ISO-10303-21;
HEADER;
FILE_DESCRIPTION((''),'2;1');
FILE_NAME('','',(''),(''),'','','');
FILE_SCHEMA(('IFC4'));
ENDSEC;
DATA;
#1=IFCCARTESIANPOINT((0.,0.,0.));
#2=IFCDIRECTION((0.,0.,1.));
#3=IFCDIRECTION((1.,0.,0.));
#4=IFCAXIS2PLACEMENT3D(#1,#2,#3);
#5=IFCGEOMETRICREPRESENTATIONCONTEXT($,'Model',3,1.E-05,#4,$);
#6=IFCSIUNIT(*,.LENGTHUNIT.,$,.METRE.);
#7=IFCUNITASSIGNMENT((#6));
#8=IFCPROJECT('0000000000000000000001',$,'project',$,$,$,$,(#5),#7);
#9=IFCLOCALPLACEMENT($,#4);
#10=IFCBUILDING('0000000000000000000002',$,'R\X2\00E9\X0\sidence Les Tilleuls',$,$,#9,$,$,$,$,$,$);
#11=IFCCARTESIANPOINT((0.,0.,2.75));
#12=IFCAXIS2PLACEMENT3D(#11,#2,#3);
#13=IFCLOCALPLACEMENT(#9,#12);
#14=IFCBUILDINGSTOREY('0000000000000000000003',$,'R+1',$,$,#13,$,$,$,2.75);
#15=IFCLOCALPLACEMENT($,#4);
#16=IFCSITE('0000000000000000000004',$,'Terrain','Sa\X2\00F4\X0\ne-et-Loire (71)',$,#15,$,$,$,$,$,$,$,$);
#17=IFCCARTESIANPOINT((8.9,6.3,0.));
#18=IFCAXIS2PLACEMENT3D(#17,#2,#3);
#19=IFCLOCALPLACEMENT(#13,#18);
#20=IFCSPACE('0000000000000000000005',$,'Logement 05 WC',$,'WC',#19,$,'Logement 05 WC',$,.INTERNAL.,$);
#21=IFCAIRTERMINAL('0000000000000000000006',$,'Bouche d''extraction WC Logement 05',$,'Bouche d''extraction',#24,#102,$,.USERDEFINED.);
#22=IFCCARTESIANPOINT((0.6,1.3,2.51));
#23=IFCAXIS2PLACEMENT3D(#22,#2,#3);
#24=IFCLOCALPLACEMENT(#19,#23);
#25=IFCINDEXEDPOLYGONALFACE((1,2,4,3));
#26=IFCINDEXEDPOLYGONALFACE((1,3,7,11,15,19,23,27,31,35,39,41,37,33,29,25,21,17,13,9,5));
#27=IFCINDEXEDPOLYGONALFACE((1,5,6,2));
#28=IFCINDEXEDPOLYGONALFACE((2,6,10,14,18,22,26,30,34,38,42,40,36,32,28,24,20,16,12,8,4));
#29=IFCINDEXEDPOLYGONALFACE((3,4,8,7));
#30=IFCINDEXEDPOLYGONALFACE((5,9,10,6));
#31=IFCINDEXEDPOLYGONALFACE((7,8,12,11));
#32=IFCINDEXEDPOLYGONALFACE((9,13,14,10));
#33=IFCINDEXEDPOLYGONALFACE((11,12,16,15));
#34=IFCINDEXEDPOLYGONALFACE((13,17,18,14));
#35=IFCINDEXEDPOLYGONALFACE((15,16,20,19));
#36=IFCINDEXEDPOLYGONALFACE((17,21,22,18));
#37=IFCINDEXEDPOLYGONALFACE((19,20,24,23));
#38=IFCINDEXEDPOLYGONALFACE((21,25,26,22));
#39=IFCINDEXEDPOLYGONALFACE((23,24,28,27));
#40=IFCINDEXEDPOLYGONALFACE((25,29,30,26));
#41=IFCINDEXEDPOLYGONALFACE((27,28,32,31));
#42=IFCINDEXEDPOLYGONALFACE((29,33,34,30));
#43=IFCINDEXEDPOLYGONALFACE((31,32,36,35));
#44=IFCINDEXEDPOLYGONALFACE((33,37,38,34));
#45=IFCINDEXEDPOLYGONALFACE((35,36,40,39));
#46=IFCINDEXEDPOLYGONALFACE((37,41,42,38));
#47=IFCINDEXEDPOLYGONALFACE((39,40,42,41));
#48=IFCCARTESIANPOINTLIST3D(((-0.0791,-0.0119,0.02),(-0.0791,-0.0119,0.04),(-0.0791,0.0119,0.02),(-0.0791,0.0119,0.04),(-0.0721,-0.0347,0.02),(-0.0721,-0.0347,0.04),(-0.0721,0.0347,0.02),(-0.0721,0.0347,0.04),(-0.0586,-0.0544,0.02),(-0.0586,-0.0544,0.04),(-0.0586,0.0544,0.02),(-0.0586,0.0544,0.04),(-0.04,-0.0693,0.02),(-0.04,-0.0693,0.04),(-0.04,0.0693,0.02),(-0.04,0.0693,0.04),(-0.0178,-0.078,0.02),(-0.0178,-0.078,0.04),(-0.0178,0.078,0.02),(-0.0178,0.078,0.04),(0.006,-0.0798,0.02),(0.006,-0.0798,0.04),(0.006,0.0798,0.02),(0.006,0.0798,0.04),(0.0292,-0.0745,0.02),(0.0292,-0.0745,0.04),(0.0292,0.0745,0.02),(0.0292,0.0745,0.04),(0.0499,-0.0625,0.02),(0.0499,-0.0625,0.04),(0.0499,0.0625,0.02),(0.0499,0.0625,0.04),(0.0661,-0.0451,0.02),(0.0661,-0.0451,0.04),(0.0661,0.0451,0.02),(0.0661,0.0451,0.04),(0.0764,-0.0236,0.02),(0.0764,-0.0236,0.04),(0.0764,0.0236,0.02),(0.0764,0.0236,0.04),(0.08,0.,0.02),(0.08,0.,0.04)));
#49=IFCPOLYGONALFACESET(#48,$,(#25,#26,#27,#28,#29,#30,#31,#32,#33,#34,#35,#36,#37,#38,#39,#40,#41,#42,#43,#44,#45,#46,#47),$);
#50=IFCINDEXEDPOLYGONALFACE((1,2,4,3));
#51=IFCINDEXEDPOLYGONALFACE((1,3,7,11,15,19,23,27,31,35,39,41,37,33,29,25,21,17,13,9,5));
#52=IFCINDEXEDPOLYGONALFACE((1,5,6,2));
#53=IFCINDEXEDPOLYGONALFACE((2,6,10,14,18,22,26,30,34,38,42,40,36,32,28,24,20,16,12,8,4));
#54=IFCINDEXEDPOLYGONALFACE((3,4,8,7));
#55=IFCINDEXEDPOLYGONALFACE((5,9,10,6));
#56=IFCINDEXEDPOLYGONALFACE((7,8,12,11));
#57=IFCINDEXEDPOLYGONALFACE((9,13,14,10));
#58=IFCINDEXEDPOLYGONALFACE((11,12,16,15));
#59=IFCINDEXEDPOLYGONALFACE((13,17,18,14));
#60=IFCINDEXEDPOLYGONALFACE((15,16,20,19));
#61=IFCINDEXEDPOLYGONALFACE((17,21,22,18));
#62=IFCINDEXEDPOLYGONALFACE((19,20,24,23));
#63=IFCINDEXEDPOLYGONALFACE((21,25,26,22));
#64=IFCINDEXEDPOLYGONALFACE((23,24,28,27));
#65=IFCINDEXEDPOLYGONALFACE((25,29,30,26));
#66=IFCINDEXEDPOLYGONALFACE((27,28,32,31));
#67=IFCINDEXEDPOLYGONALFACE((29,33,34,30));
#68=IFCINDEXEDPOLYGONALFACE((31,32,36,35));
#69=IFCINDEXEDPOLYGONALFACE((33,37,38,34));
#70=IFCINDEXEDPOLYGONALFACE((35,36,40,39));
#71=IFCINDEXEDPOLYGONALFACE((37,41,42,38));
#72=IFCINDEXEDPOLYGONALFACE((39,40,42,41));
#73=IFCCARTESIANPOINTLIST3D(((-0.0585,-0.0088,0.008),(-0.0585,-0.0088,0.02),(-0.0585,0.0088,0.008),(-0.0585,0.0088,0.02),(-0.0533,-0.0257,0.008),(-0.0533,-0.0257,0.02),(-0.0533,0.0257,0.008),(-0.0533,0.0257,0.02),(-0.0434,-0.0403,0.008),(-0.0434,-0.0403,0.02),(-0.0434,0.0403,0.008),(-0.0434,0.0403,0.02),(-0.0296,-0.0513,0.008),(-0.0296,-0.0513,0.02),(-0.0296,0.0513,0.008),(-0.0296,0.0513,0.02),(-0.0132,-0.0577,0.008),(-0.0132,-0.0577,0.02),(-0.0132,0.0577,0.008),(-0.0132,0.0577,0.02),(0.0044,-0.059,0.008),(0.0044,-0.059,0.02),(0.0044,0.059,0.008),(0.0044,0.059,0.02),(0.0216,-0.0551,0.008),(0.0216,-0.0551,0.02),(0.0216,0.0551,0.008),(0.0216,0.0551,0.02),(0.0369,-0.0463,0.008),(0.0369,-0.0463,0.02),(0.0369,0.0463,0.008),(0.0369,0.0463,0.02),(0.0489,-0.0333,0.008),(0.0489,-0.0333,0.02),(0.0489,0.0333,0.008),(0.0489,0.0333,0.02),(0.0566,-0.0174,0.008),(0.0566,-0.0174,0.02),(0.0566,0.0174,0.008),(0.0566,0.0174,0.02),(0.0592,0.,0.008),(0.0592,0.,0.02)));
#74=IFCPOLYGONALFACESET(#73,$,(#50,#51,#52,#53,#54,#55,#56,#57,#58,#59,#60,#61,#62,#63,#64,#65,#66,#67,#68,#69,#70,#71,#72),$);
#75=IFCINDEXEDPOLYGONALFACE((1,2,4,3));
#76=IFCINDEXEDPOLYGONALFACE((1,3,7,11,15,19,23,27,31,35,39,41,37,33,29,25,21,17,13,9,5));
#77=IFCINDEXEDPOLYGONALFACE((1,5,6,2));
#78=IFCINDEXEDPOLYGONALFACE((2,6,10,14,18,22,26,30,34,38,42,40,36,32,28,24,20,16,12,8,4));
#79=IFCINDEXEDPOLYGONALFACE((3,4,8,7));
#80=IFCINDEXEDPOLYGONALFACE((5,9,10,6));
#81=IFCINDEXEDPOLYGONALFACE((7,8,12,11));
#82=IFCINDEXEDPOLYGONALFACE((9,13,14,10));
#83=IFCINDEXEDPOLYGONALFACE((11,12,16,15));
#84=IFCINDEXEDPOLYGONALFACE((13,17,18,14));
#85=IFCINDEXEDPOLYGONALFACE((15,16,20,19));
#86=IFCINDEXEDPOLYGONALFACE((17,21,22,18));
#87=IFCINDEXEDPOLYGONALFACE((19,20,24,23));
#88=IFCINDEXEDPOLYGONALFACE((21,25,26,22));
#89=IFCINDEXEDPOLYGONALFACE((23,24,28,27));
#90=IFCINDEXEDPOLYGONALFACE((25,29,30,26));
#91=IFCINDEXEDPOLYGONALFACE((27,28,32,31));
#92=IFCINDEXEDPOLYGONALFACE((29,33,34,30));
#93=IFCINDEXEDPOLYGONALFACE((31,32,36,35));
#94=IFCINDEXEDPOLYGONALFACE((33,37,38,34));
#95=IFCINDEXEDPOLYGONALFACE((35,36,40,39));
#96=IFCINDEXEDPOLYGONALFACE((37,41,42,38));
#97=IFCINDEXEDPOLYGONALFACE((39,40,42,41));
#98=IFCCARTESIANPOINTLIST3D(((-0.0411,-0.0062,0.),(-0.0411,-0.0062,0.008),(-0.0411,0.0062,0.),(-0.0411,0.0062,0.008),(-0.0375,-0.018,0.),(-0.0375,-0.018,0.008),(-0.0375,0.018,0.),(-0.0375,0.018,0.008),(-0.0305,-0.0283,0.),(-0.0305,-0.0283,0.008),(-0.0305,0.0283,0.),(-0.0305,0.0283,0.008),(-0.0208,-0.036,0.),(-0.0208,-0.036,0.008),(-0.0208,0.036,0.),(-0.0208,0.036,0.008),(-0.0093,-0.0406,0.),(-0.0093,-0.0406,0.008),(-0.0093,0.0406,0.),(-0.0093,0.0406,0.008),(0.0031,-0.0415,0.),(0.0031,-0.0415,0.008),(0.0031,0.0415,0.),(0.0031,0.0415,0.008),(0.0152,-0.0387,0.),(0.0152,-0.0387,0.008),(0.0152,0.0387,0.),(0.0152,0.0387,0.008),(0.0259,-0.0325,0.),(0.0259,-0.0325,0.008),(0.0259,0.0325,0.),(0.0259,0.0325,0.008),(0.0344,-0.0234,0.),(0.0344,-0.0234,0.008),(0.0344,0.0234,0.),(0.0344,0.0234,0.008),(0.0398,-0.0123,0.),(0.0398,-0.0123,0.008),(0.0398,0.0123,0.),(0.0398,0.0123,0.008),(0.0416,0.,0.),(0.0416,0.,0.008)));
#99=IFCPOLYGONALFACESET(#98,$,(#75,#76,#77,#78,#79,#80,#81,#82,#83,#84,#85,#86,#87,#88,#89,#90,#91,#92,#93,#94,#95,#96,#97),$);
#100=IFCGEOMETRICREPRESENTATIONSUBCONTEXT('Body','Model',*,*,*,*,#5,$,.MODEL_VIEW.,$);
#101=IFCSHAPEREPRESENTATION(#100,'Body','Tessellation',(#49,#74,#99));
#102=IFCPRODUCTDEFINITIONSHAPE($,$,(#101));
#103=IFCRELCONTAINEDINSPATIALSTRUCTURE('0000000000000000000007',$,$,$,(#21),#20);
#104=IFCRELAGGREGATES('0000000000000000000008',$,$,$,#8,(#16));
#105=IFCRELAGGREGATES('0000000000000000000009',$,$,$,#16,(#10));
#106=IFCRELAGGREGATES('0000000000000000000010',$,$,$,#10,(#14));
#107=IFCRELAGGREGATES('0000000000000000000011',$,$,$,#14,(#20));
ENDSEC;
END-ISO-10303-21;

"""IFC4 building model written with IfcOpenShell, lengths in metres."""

from ifc_helpers import new_model, si_unit, frame, origin_with_axes, place, context, subcontext, project, spatial, circle, extrude, element, save


model = new_model("IFC4")

# Units and contexts
model_context = context("Model", 3, precision=1e-05, world=origin_with_axes())
body_context = subcontext(model_context, "Body", "Model", "MODEL_VIEW")
ifc_project = project(units=[si_unit("LENGTHUNIT", "METRE")], contexts=[model_context])

# Site, building, storey
site_placement = place(None, origin_with_axes())
site = spatial("IfcSite", under=ifc_project, at=site_placement, Name="Terrain", Description="Saône-et-Loire (71)")
building_placement = place(None, origin_with_axes())
building = spatial("IfcBuilding", under=site, at=building_placement, Name="Résidence Les Tilleuls")
storey_placement = place(building_placement, frame((0.0, 0.0, 2.75), z_axis=(0.0, 0.0, 1.0), x_axis=(1.0, 0.0, 0.0)))
storey = spatial("IfcBuildingStorey", under=building, at=storey_placement, Name="R+1", Elevation=2.75)

# Shared definitions
space_1_placement = place(storey_placement, frame((8.9, 6.3, 0.0), z_axis=(0.0, 0.0, 1.0), x_axis=(1.0, 0.0, 0.0)))
space_1 = spatial("IfcSpace", under=storey, at=space_1_placement, Name="Logement 05 WC", ObjectType="WC", LongName="Logement 05 WC", PredefinedType="INTERNAL")

# Air terminal
air_terminal_1_placement = place(space_1_placement, frame((0.6, 1.3, 2.51), z_axis=(0.0, 0.0, 1.0), x_axis=(1.0, 0.0, 0.0)))
element("IfcAirTerminal", 1, at=air_terminal_1_placement, inside=space_1, Name="Bouche d'extraction WC Logement 05", ObjectType="Bouche d'extraction", PredefinedType="USERDEFINED", context=body_context, shape_type="SweptSolid", body=[
    extrude(circle(Radius=0.08), frame((0.0, 0.0, 0.02), z_axis=(0.0, 0.0, 1.0), x_axis=(1.0, 0.0, 0.0)), (0.0, 0.0, 1.0), 0.02),
    extrude(circle(Radius=0.0592), frame((0.0, 0.0, 0.008), z_axis=(0.0, 0.0, 1.0), x_axis=(1.0, 0.0, 0.0)), (0.0, 0.0, 1.0), 0.012),
    extrude(circle(Radius=0.0416), origin_with_axes(), (0.0, 0.0, 1.0), 0.008),
])

save(model, "model.ifc")
